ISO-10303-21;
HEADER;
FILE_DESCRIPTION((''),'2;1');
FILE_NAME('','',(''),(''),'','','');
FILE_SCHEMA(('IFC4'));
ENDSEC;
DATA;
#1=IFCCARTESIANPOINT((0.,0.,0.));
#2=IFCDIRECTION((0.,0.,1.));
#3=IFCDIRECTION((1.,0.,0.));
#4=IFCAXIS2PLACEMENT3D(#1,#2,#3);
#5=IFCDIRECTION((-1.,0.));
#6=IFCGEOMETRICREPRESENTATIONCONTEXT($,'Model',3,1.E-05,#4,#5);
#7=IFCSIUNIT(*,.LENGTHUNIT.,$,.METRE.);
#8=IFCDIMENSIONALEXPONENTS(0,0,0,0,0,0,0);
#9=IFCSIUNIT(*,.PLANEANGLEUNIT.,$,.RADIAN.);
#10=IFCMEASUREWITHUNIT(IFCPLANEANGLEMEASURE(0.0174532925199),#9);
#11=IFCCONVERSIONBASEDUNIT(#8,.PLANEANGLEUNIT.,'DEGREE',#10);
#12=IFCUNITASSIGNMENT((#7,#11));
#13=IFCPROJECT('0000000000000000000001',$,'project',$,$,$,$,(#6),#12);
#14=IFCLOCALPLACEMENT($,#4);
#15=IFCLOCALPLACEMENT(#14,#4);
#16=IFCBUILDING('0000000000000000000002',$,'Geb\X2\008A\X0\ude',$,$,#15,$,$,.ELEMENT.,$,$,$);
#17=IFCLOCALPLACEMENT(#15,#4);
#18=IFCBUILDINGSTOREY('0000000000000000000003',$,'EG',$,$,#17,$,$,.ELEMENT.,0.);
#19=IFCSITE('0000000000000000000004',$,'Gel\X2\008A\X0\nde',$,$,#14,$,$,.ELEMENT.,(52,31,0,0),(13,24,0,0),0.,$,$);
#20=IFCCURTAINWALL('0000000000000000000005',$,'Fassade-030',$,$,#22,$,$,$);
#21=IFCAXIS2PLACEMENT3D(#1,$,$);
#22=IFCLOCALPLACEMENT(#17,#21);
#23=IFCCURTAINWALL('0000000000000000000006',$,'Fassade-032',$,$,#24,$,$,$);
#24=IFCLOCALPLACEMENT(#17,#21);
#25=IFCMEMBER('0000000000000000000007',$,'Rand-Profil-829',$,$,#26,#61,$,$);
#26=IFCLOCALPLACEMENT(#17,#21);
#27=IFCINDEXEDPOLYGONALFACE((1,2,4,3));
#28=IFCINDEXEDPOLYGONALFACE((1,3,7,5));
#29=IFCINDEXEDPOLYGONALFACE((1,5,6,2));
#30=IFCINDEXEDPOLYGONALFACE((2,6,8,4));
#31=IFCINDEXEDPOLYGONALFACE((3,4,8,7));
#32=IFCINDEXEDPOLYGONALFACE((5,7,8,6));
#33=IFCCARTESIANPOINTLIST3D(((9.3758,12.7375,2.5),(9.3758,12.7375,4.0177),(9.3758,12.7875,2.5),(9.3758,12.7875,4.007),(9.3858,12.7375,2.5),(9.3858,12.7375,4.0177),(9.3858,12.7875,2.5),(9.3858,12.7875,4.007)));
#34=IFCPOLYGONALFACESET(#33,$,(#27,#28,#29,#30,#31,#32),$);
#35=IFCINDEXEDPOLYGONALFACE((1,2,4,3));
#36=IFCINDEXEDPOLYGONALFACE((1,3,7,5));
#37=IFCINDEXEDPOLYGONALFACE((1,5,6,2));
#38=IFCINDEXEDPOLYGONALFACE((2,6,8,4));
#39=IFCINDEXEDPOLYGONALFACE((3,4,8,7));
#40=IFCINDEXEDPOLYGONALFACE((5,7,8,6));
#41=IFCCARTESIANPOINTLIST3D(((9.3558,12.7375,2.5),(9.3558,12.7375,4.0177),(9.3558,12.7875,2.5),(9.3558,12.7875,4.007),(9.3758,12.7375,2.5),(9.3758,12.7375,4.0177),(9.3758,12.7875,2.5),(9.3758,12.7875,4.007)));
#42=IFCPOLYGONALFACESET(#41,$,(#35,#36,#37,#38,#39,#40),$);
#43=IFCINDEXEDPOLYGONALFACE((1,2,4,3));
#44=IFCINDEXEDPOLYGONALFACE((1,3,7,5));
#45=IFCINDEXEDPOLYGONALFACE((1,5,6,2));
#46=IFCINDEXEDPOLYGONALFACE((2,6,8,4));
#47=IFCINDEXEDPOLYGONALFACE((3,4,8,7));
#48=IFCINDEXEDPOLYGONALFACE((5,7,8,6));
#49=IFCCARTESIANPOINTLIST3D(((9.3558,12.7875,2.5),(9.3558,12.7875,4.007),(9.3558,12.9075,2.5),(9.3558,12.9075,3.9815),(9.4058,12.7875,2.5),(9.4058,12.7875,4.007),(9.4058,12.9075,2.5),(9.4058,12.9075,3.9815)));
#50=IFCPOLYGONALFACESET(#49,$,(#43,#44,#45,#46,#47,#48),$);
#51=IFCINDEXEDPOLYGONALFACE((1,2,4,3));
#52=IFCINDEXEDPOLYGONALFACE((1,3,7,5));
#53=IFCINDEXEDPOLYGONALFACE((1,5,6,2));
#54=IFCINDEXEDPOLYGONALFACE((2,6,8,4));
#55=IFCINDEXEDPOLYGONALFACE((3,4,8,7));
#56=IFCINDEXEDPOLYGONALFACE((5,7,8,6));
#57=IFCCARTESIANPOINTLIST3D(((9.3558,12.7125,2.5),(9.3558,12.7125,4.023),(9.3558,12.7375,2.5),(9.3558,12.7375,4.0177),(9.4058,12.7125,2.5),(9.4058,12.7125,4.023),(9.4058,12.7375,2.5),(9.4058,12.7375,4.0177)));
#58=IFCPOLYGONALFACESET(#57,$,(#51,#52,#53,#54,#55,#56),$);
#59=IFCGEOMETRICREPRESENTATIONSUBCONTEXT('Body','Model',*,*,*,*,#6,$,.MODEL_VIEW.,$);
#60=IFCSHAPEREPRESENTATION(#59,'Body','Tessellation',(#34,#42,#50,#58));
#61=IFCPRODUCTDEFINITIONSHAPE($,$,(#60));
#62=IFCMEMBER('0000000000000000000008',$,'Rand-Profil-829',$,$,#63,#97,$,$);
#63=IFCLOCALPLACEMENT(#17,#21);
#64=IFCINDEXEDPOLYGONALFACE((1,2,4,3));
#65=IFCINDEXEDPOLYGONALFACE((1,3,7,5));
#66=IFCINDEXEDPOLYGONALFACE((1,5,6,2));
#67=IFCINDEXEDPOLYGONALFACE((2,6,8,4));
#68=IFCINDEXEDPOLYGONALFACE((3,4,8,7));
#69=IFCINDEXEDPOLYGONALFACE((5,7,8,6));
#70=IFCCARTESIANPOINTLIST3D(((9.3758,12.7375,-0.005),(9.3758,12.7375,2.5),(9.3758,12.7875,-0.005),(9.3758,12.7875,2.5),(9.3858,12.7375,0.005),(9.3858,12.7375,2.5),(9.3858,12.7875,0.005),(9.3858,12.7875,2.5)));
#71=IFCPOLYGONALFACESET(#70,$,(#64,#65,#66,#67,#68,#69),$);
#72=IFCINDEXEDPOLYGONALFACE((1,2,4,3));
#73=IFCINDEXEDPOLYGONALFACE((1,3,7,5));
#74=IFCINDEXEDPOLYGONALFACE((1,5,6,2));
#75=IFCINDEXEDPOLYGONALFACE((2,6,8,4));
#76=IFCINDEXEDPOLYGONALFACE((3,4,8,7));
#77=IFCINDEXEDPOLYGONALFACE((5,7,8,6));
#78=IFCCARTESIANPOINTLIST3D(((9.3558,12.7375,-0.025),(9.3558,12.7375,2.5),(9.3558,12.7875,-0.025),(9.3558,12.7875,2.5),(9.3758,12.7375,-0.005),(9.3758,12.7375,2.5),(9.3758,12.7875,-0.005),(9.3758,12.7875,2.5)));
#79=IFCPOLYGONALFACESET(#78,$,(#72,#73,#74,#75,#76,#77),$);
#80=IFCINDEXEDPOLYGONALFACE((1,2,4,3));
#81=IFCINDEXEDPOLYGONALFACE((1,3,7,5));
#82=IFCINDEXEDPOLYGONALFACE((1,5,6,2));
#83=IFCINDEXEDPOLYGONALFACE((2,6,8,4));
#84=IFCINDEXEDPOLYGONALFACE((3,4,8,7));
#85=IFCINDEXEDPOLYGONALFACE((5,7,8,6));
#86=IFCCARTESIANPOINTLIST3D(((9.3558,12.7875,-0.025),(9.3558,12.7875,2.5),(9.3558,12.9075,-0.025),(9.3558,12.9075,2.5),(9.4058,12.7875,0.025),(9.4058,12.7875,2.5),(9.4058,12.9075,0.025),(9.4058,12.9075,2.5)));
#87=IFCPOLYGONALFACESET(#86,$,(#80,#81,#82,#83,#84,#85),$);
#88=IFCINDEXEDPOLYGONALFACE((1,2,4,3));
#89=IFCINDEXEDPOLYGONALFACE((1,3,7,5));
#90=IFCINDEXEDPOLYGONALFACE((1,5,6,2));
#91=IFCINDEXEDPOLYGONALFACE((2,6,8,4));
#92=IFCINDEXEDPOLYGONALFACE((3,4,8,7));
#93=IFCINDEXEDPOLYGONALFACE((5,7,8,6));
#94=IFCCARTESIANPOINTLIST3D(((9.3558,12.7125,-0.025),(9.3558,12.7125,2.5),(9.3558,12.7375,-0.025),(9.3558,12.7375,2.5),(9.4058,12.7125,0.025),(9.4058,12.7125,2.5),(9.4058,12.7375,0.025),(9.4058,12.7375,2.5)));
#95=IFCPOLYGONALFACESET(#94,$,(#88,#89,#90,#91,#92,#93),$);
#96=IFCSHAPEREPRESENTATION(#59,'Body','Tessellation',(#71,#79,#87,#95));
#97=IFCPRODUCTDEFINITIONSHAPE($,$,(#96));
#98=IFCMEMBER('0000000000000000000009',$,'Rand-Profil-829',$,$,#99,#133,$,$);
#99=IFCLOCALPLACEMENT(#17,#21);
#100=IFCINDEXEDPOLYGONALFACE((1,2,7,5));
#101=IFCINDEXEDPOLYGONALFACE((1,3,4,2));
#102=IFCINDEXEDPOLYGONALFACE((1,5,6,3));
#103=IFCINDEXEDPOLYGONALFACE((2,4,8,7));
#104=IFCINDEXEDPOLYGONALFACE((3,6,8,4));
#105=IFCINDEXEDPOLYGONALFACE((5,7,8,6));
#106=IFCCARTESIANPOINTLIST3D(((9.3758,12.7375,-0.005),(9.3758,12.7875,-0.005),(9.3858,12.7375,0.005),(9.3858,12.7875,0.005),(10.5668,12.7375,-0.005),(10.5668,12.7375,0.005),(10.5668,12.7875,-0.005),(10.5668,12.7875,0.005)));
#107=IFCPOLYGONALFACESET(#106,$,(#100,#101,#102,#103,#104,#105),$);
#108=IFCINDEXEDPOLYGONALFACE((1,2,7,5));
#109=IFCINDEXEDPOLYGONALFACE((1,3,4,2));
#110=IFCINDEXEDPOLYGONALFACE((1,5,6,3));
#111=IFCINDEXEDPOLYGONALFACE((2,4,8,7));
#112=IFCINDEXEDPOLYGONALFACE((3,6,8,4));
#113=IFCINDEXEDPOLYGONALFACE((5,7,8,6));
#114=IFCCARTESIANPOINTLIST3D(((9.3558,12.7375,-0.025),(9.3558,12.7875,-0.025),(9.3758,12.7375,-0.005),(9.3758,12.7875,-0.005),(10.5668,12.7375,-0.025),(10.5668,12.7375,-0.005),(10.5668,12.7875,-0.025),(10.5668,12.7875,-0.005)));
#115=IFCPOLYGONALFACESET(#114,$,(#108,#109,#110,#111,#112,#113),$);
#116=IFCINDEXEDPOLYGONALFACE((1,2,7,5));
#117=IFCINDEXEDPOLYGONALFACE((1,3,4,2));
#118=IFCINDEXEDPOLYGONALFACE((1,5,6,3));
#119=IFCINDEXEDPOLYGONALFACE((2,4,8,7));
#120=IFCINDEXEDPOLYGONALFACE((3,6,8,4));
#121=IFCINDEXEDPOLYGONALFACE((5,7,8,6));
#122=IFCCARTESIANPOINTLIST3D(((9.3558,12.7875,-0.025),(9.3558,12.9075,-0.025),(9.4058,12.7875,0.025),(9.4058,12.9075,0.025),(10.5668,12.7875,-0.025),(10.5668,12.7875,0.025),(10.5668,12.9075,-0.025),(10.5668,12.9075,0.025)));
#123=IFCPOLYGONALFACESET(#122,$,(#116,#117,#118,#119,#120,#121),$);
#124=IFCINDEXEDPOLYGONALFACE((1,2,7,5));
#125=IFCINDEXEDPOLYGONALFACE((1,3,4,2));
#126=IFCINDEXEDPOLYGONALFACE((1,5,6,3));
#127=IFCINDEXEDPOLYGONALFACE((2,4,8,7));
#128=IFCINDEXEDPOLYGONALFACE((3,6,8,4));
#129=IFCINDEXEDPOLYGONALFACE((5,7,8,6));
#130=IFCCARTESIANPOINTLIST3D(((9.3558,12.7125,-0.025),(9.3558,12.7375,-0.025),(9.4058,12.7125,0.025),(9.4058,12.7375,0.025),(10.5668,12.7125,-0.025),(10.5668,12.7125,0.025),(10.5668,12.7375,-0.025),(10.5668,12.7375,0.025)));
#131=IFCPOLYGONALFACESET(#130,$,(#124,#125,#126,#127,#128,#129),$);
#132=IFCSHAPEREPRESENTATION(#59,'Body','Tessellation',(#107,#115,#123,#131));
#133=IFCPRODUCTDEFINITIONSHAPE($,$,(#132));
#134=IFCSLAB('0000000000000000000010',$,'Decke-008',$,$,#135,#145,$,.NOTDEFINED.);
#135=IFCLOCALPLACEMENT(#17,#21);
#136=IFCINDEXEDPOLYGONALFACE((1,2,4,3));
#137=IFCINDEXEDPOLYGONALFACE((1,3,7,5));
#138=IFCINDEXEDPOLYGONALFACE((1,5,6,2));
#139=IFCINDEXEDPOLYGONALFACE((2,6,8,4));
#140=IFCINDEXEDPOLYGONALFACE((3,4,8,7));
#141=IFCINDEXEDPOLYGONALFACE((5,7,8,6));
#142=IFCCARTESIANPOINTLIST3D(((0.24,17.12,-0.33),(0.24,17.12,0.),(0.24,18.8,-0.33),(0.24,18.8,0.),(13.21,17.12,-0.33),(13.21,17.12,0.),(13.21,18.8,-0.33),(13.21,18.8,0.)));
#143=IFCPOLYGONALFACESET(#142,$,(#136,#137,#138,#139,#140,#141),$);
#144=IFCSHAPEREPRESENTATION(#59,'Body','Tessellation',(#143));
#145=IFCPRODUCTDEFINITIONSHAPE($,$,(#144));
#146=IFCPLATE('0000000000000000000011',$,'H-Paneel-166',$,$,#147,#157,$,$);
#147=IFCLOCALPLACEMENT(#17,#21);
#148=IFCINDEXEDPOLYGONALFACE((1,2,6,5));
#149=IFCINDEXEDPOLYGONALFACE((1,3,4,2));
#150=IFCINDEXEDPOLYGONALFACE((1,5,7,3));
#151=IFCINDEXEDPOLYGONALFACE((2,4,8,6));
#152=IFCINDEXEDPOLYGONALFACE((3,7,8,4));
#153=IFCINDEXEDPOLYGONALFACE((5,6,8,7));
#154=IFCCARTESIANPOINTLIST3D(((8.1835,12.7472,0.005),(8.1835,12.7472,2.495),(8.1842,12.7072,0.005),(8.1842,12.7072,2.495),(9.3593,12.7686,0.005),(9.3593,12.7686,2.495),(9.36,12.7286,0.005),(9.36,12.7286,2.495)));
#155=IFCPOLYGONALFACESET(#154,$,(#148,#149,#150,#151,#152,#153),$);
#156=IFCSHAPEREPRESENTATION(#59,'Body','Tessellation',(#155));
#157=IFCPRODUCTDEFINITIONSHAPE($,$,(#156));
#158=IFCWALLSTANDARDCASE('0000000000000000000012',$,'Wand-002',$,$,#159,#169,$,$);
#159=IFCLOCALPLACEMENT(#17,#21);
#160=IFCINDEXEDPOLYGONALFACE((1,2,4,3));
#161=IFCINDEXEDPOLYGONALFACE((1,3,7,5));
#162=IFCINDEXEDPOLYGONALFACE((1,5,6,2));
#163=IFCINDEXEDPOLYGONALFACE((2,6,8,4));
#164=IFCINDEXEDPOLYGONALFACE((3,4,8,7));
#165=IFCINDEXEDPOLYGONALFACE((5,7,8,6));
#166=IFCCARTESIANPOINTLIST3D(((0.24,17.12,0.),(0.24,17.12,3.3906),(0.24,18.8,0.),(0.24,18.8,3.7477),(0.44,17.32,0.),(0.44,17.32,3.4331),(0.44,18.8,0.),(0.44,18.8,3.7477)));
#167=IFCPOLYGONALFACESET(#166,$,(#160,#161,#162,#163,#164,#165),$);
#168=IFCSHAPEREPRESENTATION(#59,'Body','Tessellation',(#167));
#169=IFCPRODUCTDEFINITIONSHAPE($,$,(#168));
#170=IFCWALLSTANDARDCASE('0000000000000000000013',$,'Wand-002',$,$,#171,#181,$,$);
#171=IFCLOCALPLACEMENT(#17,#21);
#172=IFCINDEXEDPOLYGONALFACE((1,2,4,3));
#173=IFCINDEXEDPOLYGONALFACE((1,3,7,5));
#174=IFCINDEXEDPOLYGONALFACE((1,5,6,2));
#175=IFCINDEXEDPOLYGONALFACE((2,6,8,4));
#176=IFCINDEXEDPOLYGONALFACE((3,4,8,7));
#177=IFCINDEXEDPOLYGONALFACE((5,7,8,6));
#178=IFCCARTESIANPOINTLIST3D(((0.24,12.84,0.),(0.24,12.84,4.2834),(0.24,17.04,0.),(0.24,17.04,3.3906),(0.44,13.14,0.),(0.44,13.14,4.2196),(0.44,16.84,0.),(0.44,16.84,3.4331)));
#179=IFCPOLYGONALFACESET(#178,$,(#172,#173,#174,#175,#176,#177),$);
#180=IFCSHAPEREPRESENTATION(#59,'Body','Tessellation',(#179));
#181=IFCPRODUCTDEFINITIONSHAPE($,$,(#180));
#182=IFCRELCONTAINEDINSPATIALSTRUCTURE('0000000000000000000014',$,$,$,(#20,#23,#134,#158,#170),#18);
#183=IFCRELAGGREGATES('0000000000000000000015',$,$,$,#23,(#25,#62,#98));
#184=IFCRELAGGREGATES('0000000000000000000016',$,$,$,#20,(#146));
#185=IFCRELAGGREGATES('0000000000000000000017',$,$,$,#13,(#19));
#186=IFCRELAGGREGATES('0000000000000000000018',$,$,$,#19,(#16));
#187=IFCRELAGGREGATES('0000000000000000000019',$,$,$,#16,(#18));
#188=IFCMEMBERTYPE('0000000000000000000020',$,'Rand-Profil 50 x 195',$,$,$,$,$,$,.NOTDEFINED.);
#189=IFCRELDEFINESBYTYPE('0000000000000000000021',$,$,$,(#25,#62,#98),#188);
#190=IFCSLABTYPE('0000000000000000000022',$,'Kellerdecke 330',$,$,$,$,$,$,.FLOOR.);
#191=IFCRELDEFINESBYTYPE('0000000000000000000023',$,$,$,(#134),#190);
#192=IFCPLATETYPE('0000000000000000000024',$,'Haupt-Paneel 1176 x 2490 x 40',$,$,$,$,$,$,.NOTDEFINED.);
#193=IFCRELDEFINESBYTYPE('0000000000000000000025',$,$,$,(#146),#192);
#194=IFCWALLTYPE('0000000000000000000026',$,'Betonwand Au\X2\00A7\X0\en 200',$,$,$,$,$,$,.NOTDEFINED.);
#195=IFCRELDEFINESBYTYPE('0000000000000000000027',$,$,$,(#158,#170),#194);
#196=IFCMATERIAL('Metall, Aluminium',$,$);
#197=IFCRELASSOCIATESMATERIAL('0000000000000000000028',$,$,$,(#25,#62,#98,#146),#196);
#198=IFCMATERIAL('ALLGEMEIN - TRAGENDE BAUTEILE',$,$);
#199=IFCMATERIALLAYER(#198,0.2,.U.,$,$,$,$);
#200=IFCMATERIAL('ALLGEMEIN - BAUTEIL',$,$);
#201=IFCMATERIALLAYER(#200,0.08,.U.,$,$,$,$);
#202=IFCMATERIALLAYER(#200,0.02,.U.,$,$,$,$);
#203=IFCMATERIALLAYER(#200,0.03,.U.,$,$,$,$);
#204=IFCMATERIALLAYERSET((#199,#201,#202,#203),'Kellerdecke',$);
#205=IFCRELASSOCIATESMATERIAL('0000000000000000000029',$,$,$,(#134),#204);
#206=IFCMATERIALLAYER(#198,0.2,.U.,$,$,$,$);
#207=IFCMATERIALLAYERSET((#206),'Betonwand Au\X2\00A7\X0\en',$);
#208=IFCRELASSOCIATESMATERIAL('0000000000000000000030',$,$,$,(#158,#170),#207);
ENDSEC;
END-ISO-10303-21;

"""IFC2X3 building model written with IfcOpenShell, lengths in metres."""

from ifc_helpers import new_model, entity, si_unit, converted_unit, direction, frame, origin_with_axes, place, context, subcontext, project, spatial, polyline, outline, extrude, clip, halfspace, material, layer, layer_set, layer_usage, type_object, element, aggregate, save


model = new_model("IFC2X3")

# Units and contexts
model_context = context("Model", 3, precision=1e-05, world=origin_with_axes(), true_north=direction((-1.0, 0.0)))
body_context = subcontext(model_context, "Body", "Model", "MODEL_VIEW")
ifc_project = project(units=[si_unit("LENGTHUNIT", "METRE"), converted_unit("PLANEANGLEUNIT", "DEGREE", entity("IfcPlaneAngleMeasure", 0.0174532925199), si_unit("PLANEANGLEUNIT", "RADIAN"), dimensions=[0, 0, 0, 0, 0, 0, 0])], contexts=[model_context])

# Site, building, storey
site_placement = place(None, origin_with_axes())
site = spatial("IfcSite", under=ifc_project, at=site_placement, Name="Gel\u008ande", CompositionType="ELEMENT", RefLatitude=(52, 31, 0, 0), RefLongitude=(13, 24, 0, 0), RefElevation=0.0)
building_placement = place(site_placement, origin_with_axes())
building = spatial("IfcBuilding", under=site, at=building_placement, Name="Geb\u008aude", CompositionType="ELEMENT")
storey_placement = place(building_placement, origin_with_axes())
storey = spatial("IfcBuildingStorey", under=building, at=storey_placement, Name="EG", CompositionType="ELEMENT", Elevation=0.0)

# Curtain wall
curtain_wall_1_placement = place(storey_placement, frame((8.7714, 12.7579, 0.0), z_axis=(0.0, 0.0, 1.0), x_axis=(1.0, 0.0, 0.0)))
curtain_wall_1 = element("IfcCurtainWall", 1, at=curtain_wall_1_placement, inside=storey, Name="Fassade-030")
ifc_material_1 = material(Name="Metall, Aluminium")

# Curtain wall
curtain_wall_2_placement = place(storey_placement, frame((9.9738, 12.7625, 0.0), z_axis=(0.0, 0.0, 1.0), x_axis=(1.0, 0.0, 0.0)))
curtain_wall_2 = element("IfcCurtainWall", 2, at=curtain_wall_2_placement, inside=storey, Name="Fassade-032")

# Members
member_type_1 = type_object("IfcMemberType", Name="Rand-Profil 50 x 195", PredefinedType="NOTDEFINED")
member_1_placement = place(curtain_wall_2_placement, frame((-0.593, 0.0, 2.5), z_axis=(0.0, 0.0, 1.0), x_axis=(-1.0, 0.0, 0.0)))
member_1 = element("IfcMember", 3, at=member_1_placement, type_object=member_type_1, material=ifc_material_1, Name="Rand-Profil-829", context=body_context, shape_type="Clipping", body=[
    clip(extrude(outline(polyline([(0.005, 0.025), (-0.005, 0.025), (-0.005, -0.025), (0.005, -0.025), (0.005, 0.025)])), frame((0.0, 0.0, 0.0), z_axis=(0.0, 0.0, 1.0), x_axis=(-1.0, 0.0, 0.0)), (0.0, 0.0, 1.0), 1.5177), halfspace(frame((0.0, -0.3076, 1.447), z_axis=(0.0, 0.207912, -0.978148), x_axis=(0.0, -0.978148, -0.207912)), True)),
    clip(extrude(outline(polyline([(-0.005, 0.025), (-0.025, 0.025), (-0.025, -0.025), (-0.005, -0.025), (-0.005, 0.025)])), frame((0.0, 0.0, 0.0), z_axis=(0.0, 0.0, 1.0), x_axis=(-1.0, 0.0, 0.0)), (0.0, 0.0, 1.0), 1.5177), halfspace(frame((0.0, -0.3076, 1.447), z_axis=(0.0, 0.207912, -0.978148), x_axis=(0.0, -0.978148, -0.207912)), True)),
    clip(extrude(outline(polyline([(0.025, 0.145), (-0.025, 0.145), (-0.025, 0.025), (0.025, 0.025), (0.025, 0.145)])), frame((0.0, 0.0, 0.0), z_axis=(0.0, 0.0, 1.0), x_axis=(-1.0, 0.0, 0.0)), (0.0, 0.0, 1.0), 1.507), halfspace(frame((0.0, -0.3076, 1.447), z_axis=(0.0, 0.207912, -0.978148), x_axis=(0.0, -0.978148, -0.207912)), True)),
    clip(extrude(outline(polyline([(0.025, -0.025), (-0.025, -0.025), (-0.025, -0.05), (0.025, -0.05), (0.025, -0.025)])), frame((0.0, 0.0, 0.0), z_axis=(0.0, 0.0, 1.0), x_axis=(-1.0, 0.0, 0.0)), (0.0, 0.0, 1.0), 1.523), halfspace(frame((0.0, -0.3076, 1.447), z_axis=(0.0, 0.207912, -0.978148), x_axis=(0.0, -0.978148, -0.207912)), True)),
])
member_2_placement = place(curtain_wall_2_placement, frame((-0.593, 0.0, 0.0), z_axis=(0.0, 0.0, 1.0), x_axis=(-1.0, 0.0, 0.0)))
member_2 = element("IfcMember", 4, at=member_2_placement, type_object=member_type_1, material=ifc_material_1, Name="Rand-Profil-829", context=body_context, shape_type="Clipping", body=[
    clip(extrude(outline(polyline([(-0.005, 0.025), (-0.005, -0.025), (0.005, -0.025), (0.005, 0.025), (-0.005, 0.025)])), frame((0.0, 0.0, -0.005), z_axis=(0.0, 0.0, 1.0), x_axis=(-1.0, 0.0, 0.0)), (0.0, 0.0, 1.0), 2.505), halfspace(frame((0.0, 0.0, 0.0), z_axis=(0.707107, 0.0, 0.707107), x_axis=(-0.707107, 0.0, 0.707107)), True)),
    clip(extrude(outline(polyline([(-0.025, 0.025), (-0.025, -0.025), (-0.005, -0.025), (-0.005, 0.025), (-0.025, 0.025)])), frame((0.0, 0.0, -0.025), z_axis=(0.0, 0.0, 1.0), x_axis=(-1.0, 0.0, 0.0)), (0.0, 0.0, 1.0), 2.525), halfspace(frame((0.0, 0.0, 0.0), z_axis=(0.707107, 0.0, 0.707107), x_axis=(-0.707107, 0.0, 0.707107)), True)),
    clip(extrude(outline(polyline([(-0.025, 0.145), (-0.025, 0.025), (0.025, 0.025), (0.025, 0.145), (-0.025, 0.145)])), frame((0.0, 0.0, -0.025), z_axis=(0.0, 0.0, 1.0), x_axis=(-1.0, 0.0, 0.0)), (0.0, 0.0, 1.0), 2.525), halfspace(frame((0.0, 0.0, 0.0), z_axis=(0.707107, 0.0, 0.707107), x_axis=(-0.707107, 0.0, 0.707107)), True)),
    clip(extrude(outline(polyline([(0.025, -0.05), (0.025, -0.025), (-0.025, -0.025), (-0.025, -0.05), (0.025, -0.05)])), frame((0.0, 0.0, -0.025), z_axis=(0.0, 0.0, 1.0), x_axis=(-1.0, 0.0, 0.0)), (0.0, 0.0, 1.0), 2.525), halfspace(frame((0.0, 0.0, 0.0), z_axis=(0.707107, 0.0, 0.707107), x_axis=(-0.707107, 0.0, 0.707107)), True)),
])
member_3_placement = place(curtain_wall_2_placement, frame((-0.593, 0.0, 0.0), z_axis=(1.0, 0.0, 0.0), x_axis=(0.0, 0.0, 1.0)))
member_3 = element("IfcMember", 5, at=member_3_placement, type_object=member_type_1, material=ifc_material_1, Name="Rand-Profil-829", context=body_context, shape_type="Clipping", body=[
    clip(extrude(outline(polyline([(-0.025, -0.005), (0.025, -0.005), (0.025, 0.005), (-0.025, 0.005), (-0.025, -0.005)])), frame((0.0, 0.0, -0.005), z_axis=(0.0, 0.0, 1.0), x_axis=(0.0, 1.0, 0.0)), (0.0, 0.0, 1.0), 1.191), halfspace(frame((0.0, 0.0, 0.0), z_axis=(-0.707107, 0.0, 0.707107), x_axis=(-0.707107, 0.0, -0.707107)), True)),
    clip(extrude(outline(polyline([(-0.025, 0.005), (0.025, 0.005), (0.025, 0.025), (-0.025, 0.025), (-0.025, 0.005)])), frame((0.0, 0.0, -0.025), z_axis=(0.0, 0.0, 1.0), x_axis=(0.0, 1.0, 0.0)), (0.0, 0.0, 1.0), 1.211), halfspace(frame((0.0, 0.0, 0.0), z_axis=(-0.707107, 0.0, 0.707107), x_axis=(-0.707107, 0.0, -0.707107)), True)),
    clip(extrude(outline(polyline([(-0.145, -0.025), (-0.025, -0.025), (-0.025, 0.025), (-0.145, 0.025), (-0.145, -0.025)])), frame((0.0, 0.0, -0.025), z_axis=(0.0, 0.0, 1.0), x_axis=(0.0, 1.0, 0.0)), (0.0, 0.0, 1.0), 1.211), halfspace(frame((0.0, 0.0, 0.0), z_axis=(-0.707107, 0.0, 0.707107), x_axis=(-0.707107, 0.0, -0.707107)), True)),
    clip(extrude(outline(polyline([(0.05, 0.025), (0.025, 0.025), (0.025, -0.025), (0.05, -0.025), (0.05, 0.025)])), frame((0.0, 0.0, -0.025), z_axis=(0.0, 0.0, 1.0), x_axis=(0.0, 1.0, 0.0)), (0.0, 0.0, 1.0), 1.211), halfspace(frame((0.0, 0.0, 0.0), z_axis=(-0.707107, 0.0, 0.707107), x_axis=(-0.707107, 0.0, -0.707107)), True)),
])
aggregate(curtain_wall_2, [member_1, member_2, member_3])

# Slab
ifc_material_2 = material(Name="ALLGEMEIN - TRAGENDE BAUTEILE")
ifc_layer_1 = layer(ifc_material_2, 0.2, ventilated="UNKNOWN")
ifc_material_3 = material(Name="ALLGEMEIN - BAUTEIL")
ifc_layer_2 = layer(ifc_material_3, 0.08, ventilated="UNKNOWN")
ifc_layer_3 = layer(ifc_material_3, 0.02, ventilated="UNKNOWN")
ifc_layer_4 = layer(ifc_material_3, 0.03, ventilated="UNKNOWN")
ifc_layer_set_1 = layer_set([ifc_layer_1, ifc_layer_2, ifc_layer_3, ifc_layer_4], Name="Kellerdecke")
ifc_layer_usage_1 = layer_usage(ifc_layer_set_1, "AXIS3", "NEGATIVE", 0.33)
slab_type = type_object("IfcSlabType", Name="Kellerdecke 330", PredefinedType="FLOOR")
slab_1_placement = place(storey_placement, frame((0.24, 18.8, 0.0), z_axis=(0.0, 0.0, 1.0), x_axis=(1.0, 0.0, 0.0)))
element("IfcSlab", 6, at=slab_1_placement, inside=storey, type_object=slab_type, material=ifc_layer_usage_1, Name="Decke-008", PredefinedType="NOTDEFINED", context=body_context, shape_type="SweptSolid", body=[
    extrude(outline(polyline([(0.0, 0.0), (0.0, -1.68), (12.97, -1.68), (12.97, 0.0), (0.0, 0.0)])), frame((0.0, 0.0, -0.33), z_axis=(0.0, 0.0, 1.0), x_axis=(1.0, 0.0, 0.0)), (0.0, 0.0, 1.0), 0.33),
])

# Plate
plate_type_1 = type_object("IfcPlateType", Name="Haupt-Paneel 1176 x 2490 x 40", PredefinedType="NOTDEFINED")
plate_1_placement = place(curtain_wall_1_placement, frame((0.0, 0.0, 1.25), z_axis=(0.0, 0.0, 1.0), x_axis=(-0.999835, -0.018178, 0.0)))
plate_1 = element("IfcPlate", 7, at=plate_1_placement, type_object=plate_type_1, material=ifc_material_1, Name="H-Paneel-166", context=body_context, shape_type="SweptSolid", body=[
    extrude(outline(polyline([(0.005, 2.495), (0.005, 0.005), (1.181, 0.005), (1.181, 2.495), (0.005, 2.495)])), frame((0.593, 0.0, -1.25), z_axis=(0.0, 1.0, 0.0), x_axis=(-1.0, 0.0, 0.0)), (0.0, 0.0, 1.0), 0.04),
])
aggregate(curtain_wall_1, [plate_1])

# Walls
ifc_layer_5 = layer(ifc_material_2, 0.2, ventilated="UNKNOWN")
ifc_layer_set_2 = layer_set([ifc_layer_5], Name="Betonwand Au§en")
ifc_layer_usage_2 = layer_usage(ifc_layer_set_2, "AXIS2", "NEGATIVE", 0.0)
wall_type_1 = type_object("IfcWallType", Name="Betonwand Au§en 200", PredefinedType="NOTDEFINED")
wall_1_placement = place(storey_placement, frame((0.44, 18.8, 0.0), z_axis=(0.0, 0.0, 1.0), x_axis=(0.0, -1.0, 0.0)))
element("IfcWallStandardCase", 8, at=wall_1_placement, inside=storey, type_object=wall_type_1, material=ifc_layer_usage_2, Name="Wand-002", context=body_context, shape_type="Clipping", body=[
    clip(extrude(outline(polyline([(0.0, -0.2), (1.68, -0.2), (1.48, 0.0), (0.0, 0.0), (0.0, -0.2)])), origin_with_axes(), (0.0, 0.0, 1.0), 5.67), halfspace(frame((0.7622, 0.0, 3.5857), z_axis=(-0.207912, 0.0, -0.978148), x_axis=(0.978148, 0.0, -0.207912)), True)),
])
ifc_layer_usage_3 = layer_usage(ifc_layer_set_2, "AXIS2", "POSITIVE", 0.0)
wall_2_placement = place(storey_placement, frame((0.44, 12.84, 0.0), z_axis=(0.0, 0.0, 1.0), x_axis=(0.0, 1.0, 0.0)))
element("IfcWallStandardCase", 9, at=wall_2_placement, inside=storey, type_object=wall_type_1, material=ifc_layer_usage_3, Name="Wand-002", context=body_context, shape_type="Clipping", body=[
    clip(extrude(outline(polyline([(0.3, 0.0), (4.0, 0.0), (4.2, 0.2), (0.0, 0.2), (0.3, 0.0)])), origin_with_axes(), (0.0, 0.0, 1.0), 5.67), halfspace(frame((0.8711, 0.0, 4.0982), z_axis=(-0.207912, 0.0, -0.978148), x_axis=(0.978148, 0.0, -0.207912)), True)),
])

save(model, "model.ifc")
